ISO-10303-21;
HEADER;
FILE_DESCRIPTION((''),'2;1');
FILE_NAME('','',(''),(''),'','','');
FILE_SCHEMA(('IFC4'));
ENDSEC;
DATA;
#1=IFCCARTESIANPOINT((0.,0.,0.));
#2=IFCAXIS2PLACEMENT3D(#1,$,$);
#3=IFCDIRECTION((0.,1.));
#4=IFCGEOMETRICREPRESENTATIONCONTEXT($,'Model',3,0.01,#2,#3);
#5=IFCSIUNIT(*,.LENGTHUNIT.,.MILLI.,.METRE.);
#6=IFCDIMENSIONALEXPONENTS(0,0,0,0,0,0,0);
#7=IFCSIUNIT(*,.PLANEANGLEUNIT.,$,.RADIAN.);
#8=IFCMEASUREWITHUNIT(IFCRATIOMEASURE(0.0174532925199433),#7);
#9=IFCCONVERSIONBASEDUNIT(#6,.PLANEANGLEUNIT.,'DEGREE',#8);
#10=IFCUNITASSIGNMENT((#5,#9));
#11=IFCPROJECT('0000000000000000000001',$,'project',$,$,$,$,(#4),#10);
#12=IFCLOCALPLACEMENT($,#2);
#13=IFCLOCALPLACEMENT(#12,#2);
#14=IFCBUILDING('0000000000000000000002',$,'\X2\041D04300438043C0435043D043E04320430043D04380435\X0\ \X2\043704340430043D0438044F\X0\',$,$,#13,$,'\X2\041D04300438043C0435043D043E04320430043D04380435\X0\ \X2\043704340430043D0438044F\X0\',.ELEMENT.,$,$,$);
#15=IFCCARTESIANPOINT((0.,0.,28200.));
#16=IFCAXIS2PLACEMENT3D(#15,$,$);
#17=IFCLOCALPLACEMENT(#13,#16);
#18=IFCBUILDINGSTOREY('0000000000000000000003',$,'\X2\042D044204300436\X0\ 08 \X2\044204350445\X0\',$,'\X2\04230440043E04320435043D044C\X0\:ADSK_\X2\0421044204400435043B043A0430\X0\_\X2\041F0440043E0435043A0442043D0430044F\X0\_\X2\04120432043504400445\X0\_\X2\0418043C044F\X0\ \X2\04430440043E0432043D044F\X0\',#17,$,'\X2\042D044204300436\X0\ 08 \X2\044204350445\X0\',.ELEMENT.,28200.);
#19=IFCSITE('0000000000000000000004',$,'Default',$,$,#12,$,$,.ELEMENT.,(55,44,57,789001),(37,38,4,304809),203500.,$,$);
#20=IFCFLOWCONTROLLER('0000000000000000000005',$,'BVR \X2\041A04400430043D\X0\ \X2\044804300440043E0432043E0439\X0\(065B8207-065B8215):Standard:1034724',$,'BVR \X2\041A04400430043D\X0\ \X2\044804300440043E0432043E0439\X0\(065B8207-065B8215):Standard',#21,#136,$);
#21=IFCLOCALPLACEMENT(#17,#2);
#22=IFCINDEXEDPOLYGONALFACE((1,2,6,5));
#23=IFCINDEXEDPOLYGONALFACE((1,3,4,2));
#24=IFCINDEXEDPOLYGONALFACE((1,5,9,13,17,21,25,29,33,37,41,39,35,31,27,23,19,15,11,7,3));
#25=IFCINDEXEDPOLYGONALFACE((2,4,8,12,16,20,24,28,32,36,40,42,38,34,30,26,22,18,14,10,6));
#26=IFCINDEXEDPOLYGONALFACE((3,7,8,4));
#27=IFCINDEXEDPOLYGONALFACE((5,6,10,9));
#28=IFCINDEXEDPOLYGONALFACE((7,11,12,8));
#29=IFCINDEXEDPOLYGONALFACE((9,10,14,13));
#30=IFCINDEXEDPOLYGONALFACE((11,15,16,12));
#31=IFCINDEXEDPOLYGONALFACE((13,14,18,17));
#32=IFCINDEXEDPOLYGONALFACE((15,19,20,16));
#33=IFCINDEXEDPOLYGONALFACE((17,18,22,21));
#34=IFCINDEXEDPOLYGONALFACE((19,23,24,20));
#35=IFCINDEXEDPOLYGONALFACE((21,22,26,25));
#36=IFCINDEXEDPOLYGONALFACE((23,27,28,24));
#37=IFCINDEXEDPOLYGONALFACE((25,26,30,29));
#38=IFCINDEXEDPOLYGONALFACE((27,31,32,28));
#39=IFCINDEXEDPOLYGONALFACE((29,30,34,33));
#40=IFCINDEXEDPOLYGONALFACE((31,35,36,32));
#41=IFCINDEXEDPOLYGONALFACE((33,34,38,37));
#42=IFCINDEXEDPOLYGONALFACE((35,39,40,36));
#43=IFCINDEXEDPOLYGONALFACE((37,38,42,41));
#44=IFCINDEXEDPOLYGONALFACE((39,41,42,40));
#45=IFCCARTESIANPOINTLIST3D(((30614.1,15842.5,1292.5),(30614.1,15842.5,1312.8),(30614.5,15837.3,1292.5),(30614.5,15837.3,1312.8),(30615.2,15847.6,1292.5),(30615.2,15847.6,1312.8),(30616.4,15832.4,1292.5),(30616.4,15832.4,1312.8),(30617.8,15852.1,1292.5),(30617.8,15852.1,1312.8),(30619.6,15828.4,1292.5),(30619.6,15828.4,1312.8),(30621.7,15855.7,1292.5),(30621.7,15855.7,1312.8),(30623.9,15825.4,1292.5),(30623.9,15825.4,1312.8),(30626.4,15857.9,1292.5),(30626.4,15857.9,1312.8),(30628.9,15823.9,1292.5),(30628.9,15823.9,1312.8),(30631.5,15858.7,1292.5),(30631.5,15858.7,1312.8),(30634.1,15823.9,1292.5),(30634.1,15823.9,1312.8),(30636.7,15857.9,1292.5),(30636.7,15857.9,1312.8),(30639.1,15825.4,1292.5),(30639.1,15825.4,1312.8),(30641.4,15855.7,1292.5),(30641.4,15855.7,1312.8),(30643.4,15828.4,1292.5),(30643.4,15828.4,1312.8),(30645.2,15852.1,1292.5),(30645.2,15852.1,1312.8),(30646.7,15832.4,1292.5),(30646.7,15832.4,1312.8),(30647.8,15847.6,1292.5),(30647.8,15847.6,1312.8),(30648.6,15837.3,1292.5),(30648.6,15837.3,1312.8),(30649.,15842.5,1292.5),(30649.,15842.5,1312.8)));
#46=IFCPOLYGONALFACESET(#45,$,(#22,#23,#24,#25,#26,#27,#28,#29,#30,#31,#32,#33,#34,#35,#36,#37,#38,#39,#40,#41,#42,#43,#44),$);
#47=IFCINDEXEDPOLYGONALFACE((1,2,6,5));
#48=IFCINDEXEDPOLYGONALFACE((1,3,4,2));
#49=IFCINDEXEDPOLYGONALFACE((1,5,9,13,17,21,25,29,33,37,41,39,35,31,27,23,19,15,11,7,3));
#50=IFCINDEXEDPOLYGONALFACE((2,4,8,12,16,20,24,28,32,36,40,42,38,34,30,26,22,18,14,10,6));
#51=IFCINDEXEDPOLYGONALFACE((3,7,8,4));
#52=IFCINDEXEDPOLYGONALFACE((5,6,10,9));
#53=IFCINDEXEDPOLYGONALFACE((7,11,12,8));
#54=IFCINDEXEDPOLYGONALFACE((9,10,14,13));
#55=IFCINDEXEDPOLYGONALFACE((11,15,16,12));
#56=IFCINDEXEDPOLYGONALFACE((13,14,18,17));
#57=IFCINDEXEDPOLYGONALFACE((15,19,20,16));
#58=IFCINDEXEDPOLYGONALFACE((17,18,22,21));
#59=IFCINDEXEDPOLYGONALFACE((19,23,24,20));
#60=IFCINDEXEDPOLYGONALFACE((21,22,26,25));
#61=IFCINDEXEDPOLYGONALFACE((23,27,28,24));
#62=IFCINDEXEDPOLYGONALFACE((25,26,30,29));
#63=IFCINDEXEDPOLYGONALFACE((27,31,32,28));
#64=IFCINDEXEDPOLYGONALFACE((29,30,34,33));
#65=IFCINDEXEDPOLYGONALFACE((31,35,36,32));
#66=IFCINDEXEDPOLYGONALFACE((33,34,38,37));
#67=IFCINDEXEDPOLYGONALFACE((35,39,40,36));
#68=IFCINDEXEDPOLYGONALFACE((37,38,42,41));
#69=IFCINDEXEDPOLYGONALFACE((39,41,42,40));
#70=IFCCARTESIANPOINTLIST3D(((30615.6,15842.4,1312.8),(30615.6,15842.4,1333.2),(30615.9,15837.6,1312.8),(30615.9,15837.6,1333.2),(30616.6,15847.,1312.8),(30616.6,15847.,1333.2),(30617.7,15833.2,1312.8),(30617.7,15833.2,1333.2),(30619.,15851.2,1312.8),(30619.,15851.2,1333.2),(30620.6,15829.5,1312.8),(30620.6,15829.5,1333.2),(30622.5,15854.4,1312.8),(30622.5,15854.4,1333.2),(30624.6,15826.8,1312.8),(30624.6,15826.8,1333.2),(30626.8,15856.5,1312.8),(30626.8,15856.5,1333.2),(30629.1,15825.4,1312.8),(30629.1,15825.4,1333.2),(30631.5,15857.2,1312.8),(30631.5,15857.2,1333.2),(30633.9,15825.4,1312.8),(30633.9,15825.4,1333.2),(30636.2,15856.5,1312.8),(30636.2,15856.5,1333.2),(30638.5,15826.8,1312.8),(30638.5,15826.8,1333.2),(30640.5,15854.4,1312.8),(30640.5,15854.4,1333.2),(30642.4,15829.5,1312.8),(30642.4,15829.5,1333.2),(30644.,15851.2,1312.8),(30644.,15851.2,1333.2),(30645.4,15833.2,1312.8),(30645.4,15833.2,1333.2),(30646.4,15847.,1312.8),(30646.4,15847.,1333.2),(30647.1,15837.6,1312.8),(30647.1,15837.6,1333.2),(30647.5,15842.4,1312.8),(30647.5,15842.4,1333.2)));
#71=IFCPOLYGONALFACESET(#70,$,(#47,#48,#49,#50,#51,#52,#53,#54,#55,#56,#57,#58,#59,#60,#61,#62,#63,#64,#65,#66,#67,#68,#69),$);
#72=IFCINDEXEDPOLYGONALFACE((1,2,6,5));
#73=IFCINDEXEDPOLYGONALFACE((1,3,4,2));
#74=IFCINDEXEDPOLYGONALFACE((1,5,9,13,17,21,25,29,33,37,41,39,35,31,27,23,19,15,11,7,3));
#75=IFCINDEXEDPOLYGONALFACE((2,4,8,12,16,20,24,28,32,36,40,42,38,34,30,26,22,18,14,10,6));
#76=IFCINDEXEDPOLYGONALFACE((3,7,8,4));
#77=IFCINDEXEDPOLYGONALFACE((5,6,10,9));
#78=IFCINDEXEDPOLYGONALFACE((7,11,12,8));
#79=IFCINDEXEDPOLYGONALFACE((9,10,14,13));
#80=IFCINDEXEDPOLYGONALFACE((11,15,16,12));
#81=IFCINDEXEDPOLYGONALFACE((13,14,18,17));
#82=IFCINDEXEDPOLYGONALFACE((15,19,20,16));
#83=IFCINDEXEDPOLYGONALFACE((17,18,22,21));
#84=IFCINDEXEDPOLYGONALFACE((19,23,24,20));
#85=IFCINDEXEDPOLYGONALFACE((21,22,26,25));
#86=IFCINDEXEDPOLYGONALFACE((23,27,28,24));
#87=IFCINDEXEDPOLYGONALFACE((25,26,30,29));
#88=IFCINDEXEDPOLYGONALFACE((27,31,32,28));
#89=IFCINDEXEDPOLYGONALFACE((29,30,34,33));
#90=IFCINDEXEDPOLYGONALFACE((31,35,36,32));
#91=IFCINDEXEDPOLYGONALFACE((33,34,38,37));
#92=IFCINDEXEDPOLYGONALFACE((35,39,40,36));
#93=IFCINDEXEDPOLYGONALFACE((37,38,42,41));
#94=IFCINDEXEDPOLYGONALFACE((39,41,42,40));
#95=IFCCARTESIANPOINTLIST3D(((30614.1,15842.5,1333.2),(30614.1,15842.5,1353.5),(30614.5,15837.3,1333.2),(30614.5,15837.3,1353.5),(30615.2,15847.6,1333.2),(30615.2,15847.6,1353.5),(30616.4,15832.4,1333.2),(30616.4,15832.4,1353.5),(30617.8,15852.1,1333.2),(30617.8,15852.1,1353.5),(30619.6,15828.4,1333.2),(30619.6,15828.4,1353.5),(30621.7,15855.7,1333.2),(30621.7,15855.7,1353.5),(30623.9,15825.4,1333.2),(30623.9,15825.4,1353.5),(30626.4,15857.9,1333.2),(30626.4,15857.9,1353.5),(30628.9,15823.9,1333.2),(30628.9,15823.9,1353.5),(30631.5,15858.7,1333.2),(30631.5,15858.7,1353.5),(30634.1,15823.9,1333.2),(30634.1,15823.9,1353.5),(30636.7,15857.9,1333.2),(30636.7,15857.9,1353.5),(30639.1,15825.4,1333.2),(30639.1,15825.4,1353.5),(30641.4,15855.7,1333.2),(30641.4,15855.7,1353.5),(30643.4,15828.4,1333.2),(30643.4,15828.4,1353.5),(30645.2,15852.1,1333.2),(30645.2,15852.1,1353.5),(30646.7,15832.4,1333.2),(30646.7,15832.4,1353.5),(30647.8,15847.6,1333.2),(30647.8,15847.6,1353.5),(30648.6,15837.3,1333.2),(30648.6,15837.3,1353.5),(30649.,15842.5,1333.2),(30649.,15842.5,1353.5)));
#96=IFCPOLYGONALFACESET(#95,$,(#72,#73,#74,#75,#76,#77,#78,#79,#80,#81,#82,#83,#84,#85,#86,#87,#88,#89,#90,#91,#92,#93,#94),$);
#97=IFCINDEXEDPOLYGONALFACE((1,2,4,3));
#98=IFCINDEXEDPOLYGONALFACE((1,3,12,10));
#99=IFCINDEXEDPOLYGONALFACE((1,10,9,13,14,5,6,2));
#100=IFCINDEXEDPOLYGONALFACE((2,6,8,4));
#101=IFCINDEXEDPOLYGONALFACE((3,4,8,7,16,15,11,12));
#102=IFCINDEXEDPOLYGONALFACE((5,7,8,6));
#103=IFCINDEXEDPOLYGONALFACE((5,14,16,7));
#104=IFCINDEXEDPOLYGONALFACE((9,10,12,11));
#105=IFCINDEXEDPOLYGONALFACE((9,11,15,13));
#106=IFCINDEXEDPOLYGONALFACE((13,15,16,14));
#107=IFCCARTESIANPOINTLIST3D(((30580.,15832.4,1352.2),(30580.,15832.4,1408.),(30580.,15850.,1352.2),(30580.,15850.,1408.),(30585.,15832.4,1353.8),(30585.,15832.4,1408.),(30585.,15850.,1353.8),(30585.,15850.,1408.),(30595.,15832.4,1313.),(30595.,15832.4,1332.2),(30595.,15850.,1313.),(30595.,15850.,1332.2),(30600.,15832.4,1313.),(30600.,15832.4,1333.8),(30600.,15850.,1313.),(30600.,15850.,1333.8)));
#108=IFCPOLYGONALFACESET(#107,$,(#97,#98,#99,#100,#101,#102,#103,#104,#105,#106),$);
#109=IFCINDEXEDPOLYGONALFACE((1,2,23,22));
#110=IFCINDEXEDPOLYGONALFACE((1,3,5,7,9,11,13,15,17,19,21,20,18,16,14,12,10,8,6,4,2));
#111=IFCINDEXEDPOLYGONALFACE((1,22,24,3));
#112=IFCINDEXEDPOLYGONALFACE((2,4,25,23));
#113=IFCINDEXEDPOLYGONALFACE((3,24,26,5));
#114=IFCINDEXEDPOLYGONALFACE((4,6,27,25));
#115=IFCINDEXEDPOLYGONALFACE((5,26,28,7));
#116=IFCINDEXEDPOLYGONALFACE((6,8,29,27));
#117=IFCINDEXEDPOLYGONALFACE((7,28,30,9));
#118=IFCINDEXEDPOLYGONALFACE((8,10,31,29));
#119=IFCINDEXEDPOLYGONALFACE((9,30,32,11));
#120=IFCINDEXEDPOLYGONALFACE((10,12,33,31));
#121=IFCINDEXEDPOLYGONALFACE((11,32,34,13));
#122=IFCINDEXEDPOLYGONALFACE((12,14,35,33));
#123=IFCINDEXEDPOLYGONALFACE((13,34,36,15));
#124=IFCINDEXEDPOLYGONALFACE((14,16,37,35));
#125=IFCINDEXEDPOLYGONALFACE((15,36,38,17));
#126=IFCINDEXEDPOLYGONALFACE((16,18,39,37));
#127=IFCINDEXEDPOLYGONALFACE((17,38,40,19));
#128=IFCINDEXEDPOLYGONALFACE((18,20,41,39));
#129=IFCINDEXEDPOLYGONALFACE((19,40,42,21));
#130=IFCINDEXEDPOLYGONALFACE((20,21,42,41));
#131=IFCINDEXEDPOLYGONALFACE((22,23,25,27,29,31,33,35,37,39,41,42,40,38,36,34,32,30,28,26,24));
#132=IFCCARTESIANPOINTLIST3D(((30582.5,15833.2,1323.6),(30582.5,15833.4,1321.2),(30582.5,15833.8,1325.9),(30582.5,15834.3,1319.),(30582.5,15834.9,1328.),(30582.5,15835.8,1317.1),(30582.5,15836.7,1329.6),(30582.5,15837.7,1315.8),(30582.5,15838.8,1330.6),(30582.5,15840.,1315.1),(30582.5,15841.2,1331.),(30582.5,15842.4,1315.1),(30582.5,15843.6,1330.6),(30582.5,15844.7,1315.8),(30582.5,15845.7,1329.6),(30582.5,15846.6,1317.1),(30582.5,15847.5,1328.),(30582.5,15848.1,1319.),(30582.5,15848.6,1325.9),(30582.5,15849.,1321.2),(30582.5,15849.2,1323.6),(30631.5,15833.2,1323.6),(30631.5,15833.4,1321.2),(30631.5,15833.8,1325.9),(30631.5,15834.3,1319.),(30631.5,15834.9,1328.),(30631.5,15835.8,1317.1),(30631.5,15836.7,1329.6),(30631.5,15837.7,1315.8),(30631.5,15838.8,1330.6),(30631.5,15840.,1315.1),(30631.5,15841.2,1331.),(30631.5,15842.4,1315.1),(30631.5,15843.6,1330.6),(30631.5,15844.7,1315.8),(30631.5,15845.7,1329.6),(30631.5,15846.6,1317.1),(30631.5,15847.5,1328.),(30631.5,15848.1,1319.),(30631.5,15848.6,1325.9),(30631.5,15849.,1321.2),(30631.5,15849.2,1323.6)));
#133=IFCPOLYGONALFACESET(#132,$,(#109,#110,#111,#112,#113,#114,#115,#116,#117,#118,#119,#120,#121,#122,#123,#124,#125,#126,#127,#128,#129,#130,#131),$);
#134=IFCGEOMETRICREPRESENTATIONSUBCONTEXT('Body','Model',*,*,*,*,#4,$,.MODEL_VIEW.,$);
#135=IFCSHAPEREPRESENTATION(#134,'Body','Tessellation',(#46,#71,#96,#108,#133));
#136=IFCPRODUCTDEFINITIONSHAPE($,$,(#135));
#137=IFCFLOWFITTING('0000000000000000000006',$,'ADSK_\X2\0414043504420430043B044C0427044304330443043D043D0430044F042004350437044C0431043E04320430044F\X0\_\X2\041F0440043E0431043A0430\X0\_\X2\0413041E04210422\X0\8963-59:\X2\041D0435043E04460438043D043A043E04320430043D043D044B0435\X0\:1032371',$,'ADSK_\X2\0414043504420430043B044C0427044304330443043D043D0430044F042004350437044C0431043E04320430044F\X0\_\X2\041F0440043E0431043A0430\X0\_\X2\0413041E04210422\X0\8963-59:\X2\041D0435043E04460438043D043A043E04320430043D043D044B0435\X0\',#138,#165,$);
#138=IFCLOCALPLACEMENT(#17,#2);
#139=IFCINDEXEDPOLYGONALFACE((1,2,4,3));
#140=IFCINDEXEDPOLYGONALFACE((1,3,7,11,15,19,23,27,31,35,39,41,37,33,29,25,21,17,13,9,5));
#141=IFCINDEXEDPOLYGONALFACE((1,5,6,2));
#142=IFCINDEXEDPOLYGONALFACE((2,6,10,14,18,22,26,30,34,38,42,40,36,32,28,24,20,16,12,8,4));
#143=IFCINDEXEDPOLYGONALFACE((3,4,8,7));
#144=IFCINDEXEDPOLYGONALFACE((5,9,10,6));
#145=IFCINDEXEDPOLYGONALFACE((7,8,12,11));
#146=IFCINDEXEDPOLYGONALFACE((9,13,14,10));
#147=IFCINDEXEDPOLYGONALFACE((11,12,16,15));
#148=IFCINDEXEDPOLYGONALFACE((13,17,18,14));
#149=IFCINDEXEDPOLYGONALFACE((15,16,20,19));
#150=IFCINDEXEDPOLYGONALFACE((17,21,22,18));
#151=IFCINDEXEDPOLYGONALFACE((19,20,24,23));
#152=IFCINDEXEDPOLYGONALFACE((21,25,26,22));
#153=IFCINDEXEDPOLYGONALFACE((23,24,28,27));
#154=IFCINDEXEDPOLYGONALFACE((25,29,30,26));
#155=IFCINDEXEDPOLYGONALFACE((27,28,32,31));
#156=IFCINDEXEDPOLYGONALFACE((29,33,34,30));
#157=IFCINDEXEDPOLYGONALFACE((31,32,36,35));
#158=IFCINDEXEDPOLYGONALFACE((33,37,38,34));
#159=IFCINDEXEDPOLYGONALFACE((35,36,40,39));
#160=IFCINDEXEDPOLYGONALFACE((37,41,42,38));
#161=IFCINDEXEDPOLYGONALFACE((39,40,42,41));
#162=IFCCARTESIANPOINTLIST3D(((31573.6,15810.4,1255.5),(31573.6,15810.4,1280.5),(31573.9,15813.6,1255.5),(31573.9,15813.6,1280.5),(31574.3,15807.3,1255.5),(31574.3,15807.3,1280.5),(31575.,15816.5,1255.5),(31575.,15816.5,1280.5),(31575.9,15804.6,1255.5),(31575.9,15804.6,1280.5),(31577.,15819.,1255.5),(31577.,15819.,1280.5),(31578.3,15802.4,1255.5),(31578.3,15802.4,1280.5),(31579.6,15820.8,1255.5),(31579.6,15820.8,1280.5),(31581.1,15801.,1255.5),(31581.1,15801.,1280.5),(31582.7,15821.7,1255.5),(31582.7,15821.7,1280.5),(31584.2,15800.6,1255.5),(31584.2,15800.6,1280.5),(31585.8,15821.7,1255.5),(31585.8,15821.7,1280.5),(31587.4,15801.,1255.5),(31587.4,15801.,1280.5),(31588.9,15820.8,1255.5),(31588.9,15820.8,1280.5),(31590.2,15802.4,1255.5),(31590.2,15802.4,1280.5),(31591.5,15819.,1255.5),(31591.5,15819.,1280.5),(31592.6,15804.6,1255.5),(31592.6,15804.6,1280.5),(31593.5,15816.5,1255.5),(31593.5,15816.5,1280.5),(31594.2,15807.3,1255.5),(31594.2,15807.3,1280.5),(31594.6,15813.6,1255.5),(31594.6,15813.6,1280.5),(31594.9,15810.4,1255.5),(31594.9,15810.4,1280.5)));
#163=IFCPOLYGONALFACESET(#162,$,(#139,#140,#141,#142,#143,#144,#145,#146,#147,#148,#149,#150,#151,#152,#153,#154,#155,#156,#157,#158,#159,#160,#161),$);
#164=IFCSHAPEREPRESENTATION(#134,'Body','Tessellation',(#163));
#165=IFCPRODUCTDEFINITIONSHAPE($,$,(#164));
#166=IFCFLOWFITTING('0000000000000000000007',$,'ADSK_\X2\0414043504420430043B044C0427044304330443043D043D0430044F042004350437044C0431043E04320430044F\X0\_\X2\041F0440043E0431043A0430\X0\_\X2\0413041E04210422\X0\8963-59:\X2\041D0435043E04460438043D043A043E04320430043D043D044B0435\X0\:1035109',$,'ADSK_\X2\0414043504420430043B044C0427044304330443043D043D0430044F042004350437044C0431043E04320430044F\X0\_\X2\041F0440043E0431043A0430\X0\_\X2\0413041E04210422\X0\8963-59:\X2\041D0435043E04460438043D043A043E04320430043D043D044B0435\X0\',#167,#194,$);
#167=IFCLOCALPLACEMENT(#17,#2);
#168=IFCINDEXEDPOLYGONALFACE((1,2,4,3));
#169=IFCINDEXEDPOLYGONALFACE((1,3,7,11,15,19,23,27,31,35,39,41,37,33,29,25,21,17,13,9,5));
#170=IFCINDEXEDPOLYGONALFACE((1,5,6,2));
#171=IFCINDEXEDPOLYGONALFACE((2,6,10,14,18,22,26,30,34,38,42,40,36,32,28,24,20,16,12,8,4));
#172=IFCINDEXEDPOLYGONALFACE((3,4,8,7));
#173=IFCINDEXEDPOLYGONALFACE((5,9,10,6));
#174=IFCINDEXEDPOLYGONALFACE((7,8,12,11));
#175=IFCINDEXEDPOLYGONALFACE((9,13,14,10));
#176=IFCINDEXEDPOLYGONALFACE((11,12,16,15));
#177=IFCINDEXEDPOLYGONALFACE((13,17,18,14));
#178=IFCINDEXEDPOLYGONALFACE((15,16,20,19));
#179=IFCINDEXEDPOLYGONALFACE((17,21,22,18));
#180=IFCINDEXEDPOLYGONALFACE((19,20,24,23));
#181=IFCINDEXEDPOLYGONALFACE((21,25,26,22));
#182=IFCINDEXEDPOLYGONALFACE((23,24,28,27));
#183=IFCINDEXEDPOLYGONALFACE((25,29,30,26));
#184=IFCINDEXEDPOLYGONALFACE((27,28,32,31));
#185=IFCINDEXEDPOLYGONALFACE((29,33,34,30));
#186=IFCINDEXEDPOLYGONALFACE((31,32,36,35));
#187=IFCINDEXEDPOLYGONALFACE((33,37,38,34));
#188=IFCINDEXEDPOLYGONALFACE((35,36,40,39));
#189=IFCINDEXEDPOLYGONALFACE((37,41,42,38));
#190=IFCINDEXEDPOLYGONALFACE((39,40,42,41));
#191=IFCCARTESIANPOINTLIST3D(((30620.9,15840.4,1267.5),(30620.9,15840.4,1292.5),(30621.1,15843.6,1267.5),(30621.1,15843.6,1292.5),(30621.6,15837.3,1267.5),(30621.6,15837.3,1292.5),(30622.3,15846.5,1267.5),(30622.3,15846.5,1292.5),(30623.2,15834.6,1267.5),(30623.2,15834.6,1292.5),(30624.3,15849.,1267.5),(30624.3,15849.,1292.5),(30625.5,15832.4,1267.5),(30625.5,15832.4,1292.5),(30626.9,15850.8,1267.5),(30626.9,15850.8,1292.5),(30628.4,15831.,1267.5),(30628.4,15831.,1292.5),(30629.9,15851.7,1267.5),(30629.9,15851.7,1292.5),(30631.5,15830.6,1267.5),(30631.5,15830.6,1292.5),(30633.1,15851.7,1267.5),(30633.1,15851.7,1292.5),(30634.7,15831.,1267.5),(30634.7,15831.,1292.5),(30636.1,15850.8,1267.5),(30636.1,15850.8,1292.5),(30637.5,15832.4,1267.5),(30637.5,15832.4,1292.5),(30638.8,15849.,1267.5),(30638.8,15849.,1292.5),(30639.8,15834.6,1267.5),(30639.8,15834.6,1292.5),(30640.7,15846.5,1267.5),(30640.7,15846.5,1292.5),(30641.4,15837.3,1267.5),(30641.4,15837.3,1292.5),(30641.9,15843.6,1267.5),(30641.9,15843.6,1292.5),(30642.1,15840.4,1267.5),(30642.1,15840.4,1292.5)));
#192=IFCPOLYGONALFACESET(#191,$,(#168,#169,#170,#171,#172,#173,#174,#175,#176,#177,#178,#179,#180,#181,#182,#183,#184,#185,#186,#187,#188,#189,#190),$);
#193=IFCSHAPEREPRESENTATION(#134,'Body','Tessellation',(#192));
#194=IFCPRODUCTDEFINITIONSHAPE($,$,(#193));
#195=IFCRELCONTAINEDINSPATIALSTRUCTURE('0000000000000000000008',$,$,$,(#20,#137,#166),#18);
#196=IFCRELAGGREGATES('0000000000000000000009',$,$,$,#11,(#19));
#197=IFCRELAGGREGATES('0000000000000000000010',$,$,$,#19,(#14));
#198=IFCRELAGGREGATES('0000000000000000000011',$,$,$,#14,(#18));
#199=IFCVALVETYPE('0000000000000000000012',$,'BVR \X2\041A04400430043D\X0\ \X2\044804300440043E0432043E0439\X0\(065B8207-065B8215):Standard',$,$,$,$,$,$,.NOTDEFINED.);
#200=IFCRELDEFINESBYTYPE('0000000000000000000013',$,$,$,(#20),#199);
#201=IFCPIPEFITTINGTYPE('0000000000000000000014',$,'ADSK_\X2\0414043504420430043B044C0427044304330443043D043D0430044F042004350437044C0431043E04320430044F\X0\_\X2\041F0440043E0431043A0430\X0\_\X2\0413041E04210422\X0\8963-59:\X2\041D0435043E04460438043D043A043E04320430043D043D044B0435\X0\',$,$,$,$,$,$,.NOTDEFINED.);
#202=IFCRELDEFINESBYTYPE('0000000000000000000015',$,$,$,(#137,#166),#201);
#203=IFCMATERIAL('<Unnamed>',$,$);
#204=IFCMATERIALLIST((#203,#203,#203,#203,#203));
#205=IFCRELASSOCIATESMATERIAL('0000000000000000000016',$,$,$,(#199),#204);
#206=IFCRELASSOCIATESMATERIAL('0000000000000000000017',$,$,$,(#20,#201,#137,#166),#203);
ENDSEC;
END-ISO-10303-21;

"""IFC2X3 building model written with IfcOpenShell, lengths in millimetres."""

from ifc_helpers import new_model, entity, si_unit, converted_unit, direction, frame, origin, origin_2d_with_axis, place, context, subcontext, project, spatial, polyline, circle, outline, extrude, source, transform, mapped, material, material_list, type_object, type_shapes, element, save


model = new_model("IFC2X3")

# Units and contexts
model_context = context("Model", 3, precision=0.01, world=origin(), true_north=direction((0.0, 1.0)))
body_context = subcontext(model_context, "Body", "Model", "MODEL_VIEW")
ifc_project = project(units=[si_unit("LENGTHUNIT", "METRE", prefix="MILLI"), converted_unit("PLANEANGLEUNIT", "DEGREE", entity("IfcRatioMeasure", 0.0174532925199433), si_unit("PLANEANGLEUNIT", "RADIAN"), dimensions=[0, 0, 0, 0, 0, 0, 0])], contexts=[model_context])

# Site, building, storey
site_placement = place(None, origin())
site = spatial("IfcSite", under=ifc_project, at=site_placement, Name="Default", CompositionType="ELEMENT", RefLatitude=(55, 44, 57, 789001), RefLongitude=(37, 38, 4, 304809), RefElevation=203500.0)
building_placement = place(site_placement, origin())
building = spatial("IfcBuilding", under=site, at=building_placement, Name="Наименование здания", LongName="Наименование здания", CompositionType="ELEMENT")
storey_placement = place(building_placement, frame((0.0, 0.0, 28200.0)))
storey = spatial("IfcBuildingStorey", under=building, at=storey_placement, Name="Этаж 08 тех", ObjectType="Уровень:ADSK_Стрелка_Проектная_Вверх_Имя уровня", LongName="Этаж 08 тех", CompositionType="ELEMENT", Elevation=28200.0)

# Flow controller
ifc_material = material(Name="<Unnamed>")
ifc_material_list = material_list([ifc_material, ifc_material, ifc_material, ifc_material, ifc_material])
valve_type = type_object("IfcValveType", Name="BVR Кран шаровой(065B8207-065B8215):Standard", PredefinedType="NOTDEFINED", material=ifc_material_list)
shared_shape_1 = source(origin(), body_context, "Body", "SweptSolid", [
    extrude(circle(Radius=17.5, at=origin_2d_with_axis()), frame((-30.5, 0.0, 0.0), z_axis=(1.0, 0.0, 0.0), x_axis=(0.0, 1.0, 0.0)), (0.0, 0.0, 1.0), 20.3),
    extrude(circle(Radius=16.0, at=origin_2d_with_axis()), frame((-10.2, 0.0, 0.0), z_axis=(1.0, 0.0, 0.0), x_axis=(0.0, 1.0, 0.0)), (0.0, 0.0, 1.0), 20.3),
    extrude(circle(Radius=17.5, at=origin_2d_with_axis()), frame((10.2, 0.0, 0.0), z_axis=(1.0, 0.0, 0.0), x_axis=(0.0, 1.0, 0.0)), (0.0, 0.0, 1.0), 20.3),
    extrude(outline(polyline([(-38.8, -5.0), (-38.8, -10.0), (-17.9, -10.0), (2.1, 5.0), (56.2, 5.0), (56.2, 10.0), (0.4, 10.0), (-19.6, -5.0), (-38.8, -5.0)])), frame((28.8, -8.8, 41.5), z_axis=(0.0, -1.0, 0.0), x_axis=(1.0, 0.0, 0.0)), (0.0, 0.0, -1.0), 17.5),
    extrude(circle(Radius=8.0, at=origin_2d_with_axis()), origin(), (0.0, 0.0, 1.0), 49.0),
])
type_shapes(valve_type, [shared_shape_1])
for number, where, z_axis, x_axis, name in (
    (1, (30631.5, 15841.2, 1323.0), (-1.0, 0.0, 0.0), (0.0, 0.0, 1.0), "BVR Кран шаровой(065B8207-065B8215):Standard:1034724"),
):
    element("IfcFlowController", number, at=place(storey_placement, frame(where, z_axis=z_axis, x_axis=x_axis)), inside=storey, type_object=valve_type, material=ifc_material, Name=name, ObjectType="BVR Кран шаровой(065B8207-065B8215):Standard", context=body_context, shape_type="MappedRepresentation", body=[
        mapped(shared_shape_1, transform((0.0, 0.0, 0.0), scale=1.0)),
    ])

# Flow fittings
pipe_fitting_type_1 = type_object("IfcPipeFittingType", Name="ADSK_ДетальЧугуннаяРезьбовая_Пробка_ГОСТ8963-59:Неоцинкованные", PredefinedType="NOTDEFINED", material=ifc_material)
shared_shape_2 = source(origin(), body_context, "Body", "SweptSolid", [
    extrude(circle(Radius=10.7, at=origin_2d_with_axis()), frame((0.0, 0.0, 0.0), z_axis=(1.0, 0.0, 0.0), x_axis=(0.0, 1.0, 0.0)), (0.0, 0.0, 1.0), 25.0),
])
type_shapes(pipe_fitting_type_1, [shared_shape_2])
for number, where, z_axis, x_axis, name in (
    (2, (31584.2, 15811.2, 1280.5), (-1.0, 0.0, 0.0), (0.0, 0.0, -1.0), "ADSK_ДетальЧугуннаяРезьбовая_Пробка_ГОСТ8963-59:Неоцинкованные:1032371"),
    (3, (30631.5, 15841.2, 1292.5), (-1.0, 0.0, 0.0), (0.0, 0.0, -1.0), "ADSK_ДетальЧугуннаяРезьбовая_Пробка_ГОСТ8963-59:Неоцинкованные:1035109"),
):
    element("IfcFlowFitting", number, at=place(storey_placement, frame(where, z_axis=z_axis, x_axis=x_axis)), inside=storey, type_object=pipe_fitting_type_1, material=ifc_material, Name=name, ObjectType="ADSK_ДетальЧугуннаяРезьбовая_Пробка_ГОСТ8963-59:Неоцинкованные", context=body_context, shape_type="MappedRepresentation", body=[
        mapped(shared_shape_2, transform((0.0, 0.0, 0.0), scale=1.0)),
    ])

save(model, "model.ifc")
